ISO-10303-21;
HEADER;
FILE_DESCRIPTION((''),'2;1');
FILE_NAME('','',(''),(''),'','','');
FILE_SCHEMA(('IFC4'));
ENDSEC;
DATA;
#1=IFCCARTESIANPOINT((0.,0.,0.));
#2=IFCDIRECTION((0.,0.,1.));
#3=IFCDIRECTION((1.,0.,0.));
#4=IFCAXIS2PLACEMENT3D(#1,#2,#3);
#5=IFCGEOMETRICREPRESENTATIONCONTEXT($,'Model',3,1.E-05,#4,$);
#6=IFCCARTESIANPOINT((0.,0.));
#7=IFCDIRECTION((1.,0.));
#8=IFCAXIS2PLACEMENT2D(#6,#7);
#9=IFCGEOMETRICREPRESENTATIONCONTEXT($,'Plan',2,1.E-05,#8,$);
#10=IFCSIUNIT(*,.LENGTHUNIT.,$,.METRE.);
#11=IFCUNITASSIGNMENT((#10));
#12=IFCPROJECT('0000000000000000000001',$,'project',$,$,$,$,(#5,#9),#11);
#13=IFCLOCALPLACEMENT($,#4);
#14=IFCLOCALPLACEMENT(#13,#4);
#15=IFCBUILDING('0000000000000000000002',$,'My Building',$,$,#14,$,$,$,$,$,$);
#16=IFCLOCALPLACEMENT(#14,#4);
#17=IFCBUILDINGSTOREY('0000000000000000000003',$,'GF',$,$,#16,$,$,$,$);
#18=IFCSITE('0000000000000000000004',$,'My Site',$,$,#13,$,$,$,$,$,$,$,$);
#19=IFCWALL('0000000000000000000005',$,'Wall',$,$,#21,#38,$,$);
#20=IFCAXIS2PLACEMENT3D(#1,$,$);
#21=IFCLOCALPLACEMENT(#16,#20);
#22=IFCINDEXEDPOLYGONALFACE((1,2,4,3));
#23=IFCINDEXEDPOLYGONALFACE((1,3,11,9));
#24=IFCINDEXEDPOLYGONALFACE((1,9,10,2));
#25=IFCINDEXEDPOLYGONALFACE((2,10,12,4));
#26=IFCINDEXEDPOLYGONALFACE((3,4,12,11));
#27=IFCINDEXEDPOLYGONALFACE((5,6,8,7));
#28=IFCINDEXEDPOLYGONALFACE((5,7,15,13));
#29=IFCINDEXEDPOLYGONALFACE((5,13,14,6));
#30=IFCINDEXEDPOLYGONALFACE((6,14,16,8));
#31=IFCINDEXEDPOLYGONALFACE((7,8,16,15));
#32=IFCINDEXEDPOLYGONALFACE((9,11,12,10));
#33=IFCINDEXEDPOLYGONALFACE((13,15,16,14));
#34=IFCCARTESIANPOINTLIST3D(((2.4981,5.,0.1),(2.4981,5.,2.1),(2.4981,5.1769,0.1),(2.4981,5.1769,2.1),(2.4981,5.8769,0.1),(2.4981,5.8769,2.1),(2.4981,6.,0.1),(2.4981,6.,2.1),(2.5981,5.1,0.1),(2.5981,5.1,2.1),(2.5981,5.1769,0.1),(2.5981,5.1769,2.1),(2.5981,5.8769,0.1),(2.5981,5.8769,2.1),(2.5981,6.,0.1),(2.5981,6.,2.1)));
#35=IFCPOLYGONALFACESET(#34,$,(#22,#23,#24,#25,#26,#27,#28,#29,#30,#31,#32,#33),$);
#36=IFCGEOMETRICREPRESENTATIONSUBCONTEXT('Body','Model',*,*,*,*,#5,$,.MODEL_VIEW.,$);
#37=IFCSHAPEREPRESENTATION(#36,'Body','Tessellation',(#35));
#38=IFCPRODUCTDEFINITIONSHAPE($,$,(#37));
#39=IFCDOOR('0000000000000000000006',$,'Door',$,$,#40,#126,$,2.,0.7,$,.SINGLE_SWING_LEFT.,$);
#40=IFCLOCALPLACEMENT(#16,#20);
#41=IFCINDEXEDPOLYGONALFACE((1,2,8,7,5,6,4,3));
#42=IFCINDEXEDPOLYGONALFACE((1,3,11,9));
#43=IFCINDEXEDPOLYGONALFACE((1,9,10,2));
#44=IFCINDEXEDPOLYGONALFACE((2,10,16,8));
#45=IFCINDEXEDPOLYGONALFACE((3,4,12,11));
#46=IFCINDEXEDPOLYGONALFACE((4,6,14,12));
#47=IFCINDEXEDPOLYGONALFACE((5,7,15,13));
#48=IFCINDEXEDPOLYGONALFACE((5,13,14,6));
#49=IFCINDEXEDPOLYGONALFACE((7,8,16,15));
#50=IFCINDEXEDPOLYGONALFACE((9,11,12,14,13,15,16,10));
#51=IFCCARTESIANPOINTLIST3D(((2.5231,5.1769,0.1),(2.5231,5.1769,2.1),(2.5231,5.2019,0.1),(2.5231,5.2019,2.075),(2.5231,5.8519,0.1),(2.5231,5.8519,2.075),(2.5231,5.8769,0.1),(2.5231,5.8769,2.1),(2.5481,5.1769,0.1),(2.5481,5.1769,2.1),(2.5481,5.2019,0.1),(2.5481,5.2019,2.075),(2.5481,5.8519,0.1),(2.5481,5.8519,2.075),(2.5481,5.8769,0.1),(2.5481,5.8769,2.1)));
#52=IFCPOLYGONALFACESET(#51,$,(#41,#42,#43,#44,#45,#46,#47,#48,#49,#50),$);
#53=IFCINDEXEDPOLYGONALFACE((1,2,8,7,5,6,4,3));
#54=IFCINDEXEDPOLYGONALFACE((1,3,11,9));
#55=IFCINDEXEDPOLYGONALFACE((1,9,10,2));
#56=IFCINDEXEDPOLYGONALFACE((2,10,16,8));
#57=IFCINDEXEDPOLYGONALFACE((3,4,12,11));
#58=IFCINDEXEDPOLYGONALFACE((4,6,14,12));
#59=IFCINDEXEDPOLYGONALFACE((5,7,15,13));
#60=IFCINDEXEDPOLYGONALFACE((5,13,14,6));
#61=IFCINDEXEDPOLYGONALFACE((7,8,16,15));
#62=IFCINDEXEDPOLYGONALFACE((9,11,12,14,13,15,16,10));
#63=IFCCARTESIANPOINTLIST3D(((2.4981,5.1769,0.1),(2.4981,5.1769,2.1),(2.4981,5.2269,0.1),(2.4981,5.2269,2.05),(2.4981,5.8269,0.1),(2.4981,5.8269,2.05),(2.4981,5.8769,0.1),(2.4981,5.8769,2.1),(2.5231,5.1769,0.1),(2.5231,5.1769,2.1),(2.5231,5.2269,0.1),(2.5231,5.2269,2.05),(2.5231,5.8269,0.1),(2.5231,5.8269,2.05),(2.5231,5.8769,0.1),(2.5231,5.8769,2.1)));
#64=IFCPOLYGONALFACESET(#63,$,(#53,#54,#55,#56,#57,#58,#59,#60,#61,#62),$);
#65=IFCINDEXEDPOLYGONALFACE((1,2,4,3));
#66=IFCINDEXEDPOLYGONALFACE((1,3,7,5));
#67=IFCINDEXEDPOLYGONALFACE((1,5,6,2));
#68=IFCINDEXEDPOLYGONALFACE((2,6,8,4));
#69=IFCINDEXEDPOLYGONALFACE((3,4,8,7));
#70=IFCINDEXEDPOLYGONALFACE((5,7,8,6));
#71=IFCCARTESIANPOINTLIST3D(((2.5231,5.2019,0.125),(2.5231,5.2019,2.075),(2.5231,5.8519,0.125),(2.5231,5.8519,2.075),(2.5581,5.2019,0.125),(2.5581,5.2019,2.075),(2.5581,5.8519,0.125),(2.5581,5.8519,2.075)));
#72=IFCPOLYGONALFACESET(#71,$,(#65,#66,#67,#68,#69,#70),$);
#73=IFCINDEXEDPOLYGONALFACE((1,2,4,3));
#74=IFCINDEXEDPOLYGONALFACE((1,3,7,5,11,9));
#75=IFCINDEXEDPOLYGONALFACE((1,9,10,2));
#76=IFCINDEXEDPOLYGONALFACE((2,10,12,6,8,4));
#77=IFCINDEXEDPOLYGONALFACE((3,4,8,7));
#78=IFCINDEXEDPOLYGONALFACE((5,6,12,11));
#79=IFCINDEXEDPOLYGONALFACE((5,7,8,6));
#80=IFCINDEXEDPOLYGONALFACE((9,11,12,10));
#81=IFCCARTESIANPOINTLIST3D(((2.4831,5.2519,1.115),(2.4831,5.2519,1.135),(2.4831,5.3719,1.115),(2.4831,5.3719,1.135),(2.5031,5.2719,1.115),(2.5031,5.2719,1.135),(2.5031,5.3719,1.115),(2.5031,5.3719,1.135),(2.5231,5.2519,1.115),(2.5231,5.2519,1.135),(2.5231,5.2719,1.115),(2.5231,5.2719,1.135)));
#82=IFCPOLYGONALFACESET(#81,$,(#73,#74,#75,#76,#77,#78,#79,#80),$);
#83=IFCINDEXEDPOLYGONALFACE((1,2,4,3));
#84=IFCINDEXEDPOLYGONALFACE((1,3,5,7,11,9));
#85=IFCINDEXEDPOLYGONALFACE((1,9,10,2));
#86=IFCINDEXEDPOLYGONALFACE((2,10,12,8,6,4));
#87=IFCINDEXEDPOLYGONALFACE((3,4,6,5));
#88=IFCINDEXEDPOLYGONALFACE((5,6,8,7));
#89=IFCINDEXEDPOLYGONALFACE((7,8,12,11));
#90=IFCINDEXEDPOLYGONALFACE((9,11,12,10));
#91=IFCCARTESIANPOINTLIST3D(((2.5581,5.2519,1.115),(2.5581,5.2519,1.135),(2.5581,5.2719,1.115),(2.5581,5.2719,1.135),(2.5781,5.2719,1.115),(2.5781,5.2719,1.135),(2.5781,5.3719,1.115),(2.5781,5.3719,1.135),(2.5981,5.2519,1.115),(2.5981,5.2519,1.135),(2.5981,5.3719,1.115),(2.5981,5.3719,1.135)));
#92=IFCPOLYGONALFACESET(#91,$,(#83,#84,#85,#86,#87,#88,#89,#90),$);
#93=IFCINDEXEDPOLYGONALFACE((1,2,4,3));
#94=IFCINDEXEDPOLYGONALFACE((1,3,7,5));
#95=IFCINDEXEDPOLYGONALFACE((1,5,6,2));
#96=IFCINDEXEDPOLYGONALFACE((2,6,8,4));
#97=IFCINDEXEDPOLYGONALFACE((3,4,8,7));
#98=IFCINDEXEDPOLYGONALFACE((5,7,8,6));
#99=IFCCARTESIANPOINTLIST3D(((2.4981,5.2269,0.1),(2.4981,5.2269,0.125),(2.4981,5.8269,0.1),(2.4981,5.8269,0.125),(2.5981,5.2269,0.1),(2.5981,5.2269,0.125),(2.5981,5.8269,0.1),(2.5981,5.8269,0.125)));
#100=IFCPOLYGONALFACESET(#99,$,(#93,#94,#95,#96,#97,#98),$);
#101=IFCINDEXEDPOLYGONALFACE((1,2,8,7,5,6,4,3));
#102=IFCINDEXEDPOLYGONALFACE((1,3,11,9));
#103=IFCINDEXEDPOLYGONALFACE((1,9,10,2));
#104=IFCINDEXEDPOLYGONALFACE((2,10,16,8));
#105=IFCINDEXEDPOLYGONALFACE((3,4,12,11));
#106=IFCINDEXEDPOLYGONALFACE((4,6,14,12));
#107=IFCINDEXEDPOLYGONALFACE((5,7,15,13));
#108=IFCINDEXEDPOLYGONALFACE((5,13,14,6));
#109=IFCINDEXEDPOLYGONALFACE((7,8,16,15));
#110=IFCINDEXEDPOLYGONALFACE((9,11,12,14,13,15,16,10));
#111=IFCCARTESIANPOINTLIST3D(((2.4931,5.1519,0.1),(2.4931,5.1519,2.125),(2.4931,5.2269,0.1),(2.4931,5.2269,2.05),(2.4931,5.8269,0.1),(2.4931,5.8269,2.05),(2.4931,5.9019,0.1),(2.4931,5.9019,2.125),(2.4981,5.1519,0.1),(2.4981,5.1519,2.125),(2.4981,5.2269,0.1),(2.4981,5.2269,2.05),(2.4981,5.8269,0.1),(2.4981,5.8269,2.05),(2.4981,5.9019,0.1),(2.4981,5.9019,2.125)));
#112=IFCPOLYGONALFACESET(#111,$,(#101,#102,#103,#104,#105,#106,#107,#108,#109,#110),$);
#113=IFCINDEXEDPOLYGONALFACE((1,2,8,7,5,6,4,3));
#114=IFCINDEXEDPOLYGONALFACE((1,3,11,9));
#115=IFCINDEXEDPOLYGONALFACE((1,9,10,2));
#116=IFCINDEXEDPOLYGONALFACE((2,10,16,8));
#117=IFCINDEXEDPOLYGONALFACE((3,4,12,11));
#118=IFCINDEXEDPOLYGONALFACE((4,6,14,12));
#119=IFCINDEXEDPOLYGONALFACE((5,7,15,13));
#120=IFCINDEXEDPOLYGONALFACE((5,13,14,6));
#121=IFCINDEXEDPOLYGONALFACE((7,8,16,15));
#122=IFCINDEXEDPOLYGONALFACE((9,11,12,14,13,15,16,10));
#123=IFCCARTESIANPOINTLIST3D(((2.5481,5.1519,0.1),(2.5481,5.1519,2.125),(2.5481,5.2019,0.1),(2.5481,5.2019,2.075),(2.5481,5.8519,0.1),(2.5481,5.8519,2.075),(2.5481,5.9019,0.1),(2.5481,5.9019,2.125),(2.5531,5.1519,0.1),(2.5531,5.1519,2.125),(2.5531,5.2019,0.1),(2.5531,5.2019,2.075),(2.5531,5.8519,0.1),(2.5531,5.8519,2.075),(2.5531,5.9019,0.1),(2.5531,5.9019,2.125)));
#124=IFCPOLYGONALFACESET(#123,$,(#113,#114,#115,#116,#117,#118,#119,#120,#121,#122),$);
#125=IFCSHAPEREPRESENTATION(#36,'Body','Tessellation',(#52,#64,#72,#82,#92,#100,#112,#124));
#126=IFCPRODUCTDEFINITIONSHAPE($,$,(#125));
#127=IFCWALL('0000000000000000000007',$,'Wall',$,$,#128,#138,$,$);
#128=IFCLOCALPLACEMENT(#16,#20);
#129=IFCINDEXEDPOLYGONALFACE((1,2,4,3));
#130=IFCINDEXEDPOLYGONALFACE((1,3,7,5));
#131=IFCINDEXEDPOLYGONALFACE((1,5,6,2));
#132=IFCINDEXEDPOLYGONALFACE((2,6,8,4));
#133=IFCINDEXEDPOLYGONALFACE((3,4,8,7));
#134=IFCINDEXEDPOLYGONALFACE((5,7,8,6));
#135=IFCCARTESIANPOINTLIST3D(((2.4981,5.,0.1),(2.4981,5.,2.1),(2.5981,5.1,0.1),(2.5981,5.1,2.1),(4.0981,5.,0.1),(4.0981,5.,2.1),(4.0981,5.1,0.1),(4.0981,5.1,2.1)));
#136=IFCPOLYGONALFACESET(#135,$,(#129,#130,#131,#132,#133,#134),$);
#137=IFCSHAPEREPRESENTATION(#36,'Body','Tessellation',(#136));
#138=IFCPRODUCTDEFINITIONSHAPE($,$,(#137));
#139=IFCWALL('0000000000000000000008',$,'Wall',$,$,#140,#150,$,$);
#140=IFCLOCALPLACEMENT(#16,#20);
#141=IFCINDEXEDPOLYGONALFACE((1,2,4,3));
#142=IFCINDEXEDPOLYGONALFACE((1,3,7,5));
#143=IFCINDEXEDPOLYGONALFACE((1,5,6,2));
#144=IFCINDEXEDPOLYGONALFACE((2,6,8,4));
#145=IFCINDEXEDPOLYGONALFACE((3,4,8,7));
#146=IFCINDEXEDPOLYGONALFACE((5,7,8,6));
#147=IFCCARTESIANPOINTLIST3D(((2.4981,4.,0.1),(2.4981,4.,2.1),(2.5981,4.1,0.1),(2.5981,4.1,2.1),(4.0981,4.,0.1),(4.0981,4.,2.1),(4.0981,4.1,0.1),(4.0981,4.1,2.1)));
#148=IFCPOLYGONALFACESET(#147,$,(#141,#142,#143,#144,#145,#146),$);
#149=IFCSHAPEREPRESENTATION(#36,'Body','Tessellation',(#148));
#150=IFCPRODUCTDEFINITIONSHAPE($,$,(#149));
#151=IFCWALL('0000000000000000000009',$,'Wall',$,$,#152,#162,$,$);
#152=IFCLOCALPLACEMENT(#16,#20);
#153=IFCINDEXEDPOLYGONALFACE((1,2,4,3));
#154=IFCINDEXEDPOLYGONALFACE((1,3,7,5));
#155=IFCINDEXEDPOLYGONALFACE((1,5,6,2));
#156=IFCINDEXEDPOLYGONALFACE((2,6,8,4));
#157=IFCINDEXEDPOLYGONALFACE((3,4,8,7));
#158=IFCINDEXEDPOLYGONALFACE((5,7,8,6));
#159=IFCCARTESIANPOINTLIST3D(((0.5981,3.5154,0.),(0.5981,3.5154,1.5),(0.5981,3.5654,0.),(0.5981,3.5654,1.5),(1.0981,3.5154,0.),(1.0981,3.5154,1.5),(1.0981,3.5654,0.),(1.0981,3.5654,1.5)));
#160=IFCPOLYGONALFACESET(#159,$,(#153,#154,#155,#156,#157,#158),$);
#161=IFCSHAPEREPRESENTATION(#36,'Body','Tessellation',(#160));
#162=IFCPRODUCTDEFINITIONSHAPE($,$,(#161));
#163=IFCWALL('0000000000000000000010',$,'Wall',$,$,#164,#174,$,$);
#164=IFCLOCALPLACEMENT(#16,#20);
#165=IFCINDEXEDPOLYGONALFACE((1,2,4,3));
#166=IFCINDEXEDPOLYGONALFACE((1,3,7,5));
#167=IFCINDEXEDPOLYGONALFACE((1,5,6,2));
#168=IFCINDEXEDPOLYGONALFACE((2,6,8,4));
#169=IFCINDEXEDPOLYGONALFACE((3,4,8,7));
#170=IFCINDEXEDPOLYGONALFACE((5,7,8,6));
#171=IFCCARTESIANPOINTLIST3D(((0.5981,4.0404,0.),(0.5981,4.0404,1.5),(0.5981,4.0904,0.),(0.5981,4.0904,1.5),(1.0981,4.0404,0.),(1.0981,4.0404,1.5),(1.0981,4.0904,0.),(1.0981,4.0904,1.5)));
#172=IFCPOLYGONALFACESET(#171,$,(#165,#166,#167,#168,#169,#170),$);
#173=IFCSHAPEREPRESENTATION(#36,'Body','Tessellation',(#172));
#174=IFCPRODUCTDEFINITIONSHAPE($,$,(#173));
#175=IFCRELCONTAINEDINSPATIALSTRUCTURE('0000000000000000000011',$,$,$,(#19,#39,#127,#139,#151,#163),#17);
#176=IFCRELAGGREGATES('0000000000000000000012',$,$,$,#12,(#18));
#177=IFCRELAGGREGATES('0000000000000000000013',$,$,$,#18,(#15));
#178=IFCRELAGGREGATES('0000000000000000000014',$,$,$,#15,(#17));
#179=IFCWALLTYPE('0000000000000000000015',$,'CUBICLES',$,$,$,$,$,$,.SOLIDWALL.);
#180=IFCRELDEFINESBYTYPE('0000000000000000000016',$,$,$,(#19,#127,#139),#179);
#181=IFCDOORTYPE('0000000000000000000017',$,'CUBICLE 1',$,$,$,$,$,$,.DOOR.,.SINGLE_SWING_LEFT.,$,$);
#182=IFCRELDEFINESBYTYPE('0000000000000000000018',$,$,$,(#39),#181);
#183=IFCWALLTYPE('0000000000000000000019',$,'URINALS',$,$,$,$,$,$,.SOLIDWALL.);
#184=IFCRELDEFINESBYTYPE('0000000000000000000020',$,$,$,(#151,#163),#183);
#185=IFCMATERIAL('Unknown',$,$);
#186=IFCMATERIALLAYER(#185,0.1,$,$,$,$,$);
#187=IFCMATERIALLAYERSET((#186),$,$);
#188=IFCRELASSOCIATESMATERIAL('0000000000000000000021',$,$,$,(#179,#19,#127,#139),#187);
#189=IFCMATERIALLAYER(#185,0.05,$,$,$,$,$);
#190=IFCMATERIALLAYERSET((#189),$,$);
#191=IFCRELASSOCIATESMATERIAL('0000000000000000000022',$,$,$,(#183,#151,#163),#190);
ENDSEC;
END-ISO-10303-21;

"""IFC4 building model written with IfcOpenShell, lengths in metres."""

from ifc_helpers import new_model, entity, si_unit, frame, origin_with_axes, origin_2d_with_axis, place, context, subcontext, project, spatial, line, indexed_curve, outline, extrude, shape, source, transform, mapped, material, layer, layer_set, layer_usage, type_object, type_shapes, element, fill, save


model = new_model("IFC4")

# Units and contexts
model_context = context("Model", 3, precision=1e-05, world=origin_with_axes())
plan_context = context("Plan", 2, precision=1e-05, world=origin_2d_with_axis())
body_context_1 = subcontext(model_context, "Body", "Model", "MODEL_VIEW")
body_context_2 = subcontext(plan_context, "Body", "Plan", "PLAN_VIEW")
ifc_project = project(units=[si_unit("LENGTHUNIT", "METRE")], contexts=[model_context, plan_context])

# Site, building, storey
site_placement = place(None, origin_with_axes())
site = spatial("IfcSite", under=ifc_project, at=site_placement, Name="My Site")
building_placement = place(site_placement, origin_with_axes())
building = spatial("IfcBuilding", under=site, at=building_placement, Name="My Building")
storey_placement = place(building_placement, origin_with_axes())
storey = spatial("IfcBuildingStorey", under=building, at=storey_placement, Name="GF")

# Shared definitions
ifc_material = material(Name="Unknown")

# Wall, opening, door
ifc_layer_1 = layer(ifc_material, 0.1)
ifc_layer_set_1 = layer_set([ifc_layer_1])
wall_type_1 = type_object("IfcWallType", Name="CUBICLES", PredefinedType="SOLIDWALL", material=ifc_layer_set_1)
ifc_layer_usage_1 = layer_usage(ifc_layer_set_1, "AXIS2", "POSITIVE", 0.0)
wall_1_placement = place(storey_placement, frame((2.5981, 5.0, 0.1), z_axis=(0.0, 0.0, 1.0), x_axis=(0.0, 1.0, 0.0)))
wall_1 = element("IfcWall", 1, at=wall_1_placement, inside=storey, type_object=wall_type_1, material=ifc_layer_usage_1, Name="Wall", context=body_context_1, shape_type="SweptSolid", body=[
    extrude(outline(indexed_curve([(0.1, 0.0), (0.0, 0.1), (1.0, 0.1), (1.0, 0.0)], segments=[line(1, 2, 3, 4, 1)])), origin_with_axes(), (0.0, 0.0, 1.0), 2.0),
])
shared_shape_1 = source(origin_with_axes(), body_context_1, "Body", "SweptSolid", [
    extrude(outline(indexed_curve([(0.0, 0.0), (0.7, 0.0), (0.7, 2.0), (0.0, 2.0)], segments=[line(1, 2, 3, 4, 1)])), frame((0.0, -0.6, 0.0), z_axis=(0.0, -1.0, 0.0), x_axis=(1.0, 0.0, 0.0)), (0.0, 0.0, -1.0), 1.2),
])
opening_1_placement = place(wall_1_placement, frame((0.8769, 0.1, 0.0), z_axis=(0.0, 0.0, 1.0), x_axis=(-1.0, 0.0, 0.0)))
opening_1 = element("IfcOpeningElement", 2, at=opening_1_placement, cuts=wall_1, PredefinedType="OPENING", context=body_context_1, shape_type="MappedRepresentation", body=[
    mapped(shared_shape_1, transform((0.0, 0.0, 0.0), x_axis=(1.0, 0.0, 0.0), y_axis=(0.0, 1.0, 0.0), z_axis=(0.0, 0.0, 1.0), scale=1.0)),
])
door_type_1 = type_object("IfcDoorType", Name="CUBICLE 1", OperationType="SINGLE_SWING_LEFT", PredefinedType="DOOR")
shared_shape_2 = source(origin_with_axes(), body_context_1, "Body", "SweptSolid", [
    extrude(outline(indexed_curve([(0.0, 0.0), (0.0, 2.0), (0.7, 2.0), (0.7, 0.0), (0.675, 0.0), (0.675, 1.975), (0.025, 1.975), (0.025, 0.0)], segments=[line(1, 2, 3, 4, 5, 6, 7, 8, 1)])), frame((0.0, 0.025, 0.0), z_axis=(0.0, -1.0, 0.0), x_axis=(1.0, 0.0, 0.0)), (0.0, 0.0, -1.0), 0.025),
    extrude(outline(indexed_curve([(0.0, 0.0), (0.0, 2.0), (0.7, 2.0), (0.7, 0.0), (0.65, 0.0), (0.65, 1.95), (0.05, 1.95), (0.05, 0.0)], segments=[line(1, 2, 3, 4, 5, 6, 7, 8, 1)])), frame((0.0, 0.0, 0.0), z_axis=(0.0, -1.0, 0.0), x_axis=(1.0, 0.0, 0.0)), (0.0, 0.0, -1.0), 0.025),
    extrude(outline(indexed_curve([(0.0, 0.0), (0.65, 0.0), (0.65, 0.035), (0.0, 0.035)], segments=[line(1, 2, 3, 4, 1)])), frame((0.025, 0.025, 0.025), z_axis=(0.0, 0.0, 1.0), x_axis=(1.0, 0.0, 0.0)), (0.0, 0.0, 1.0), 1.95),
    extrude(outline(indexed_curve([(0.0, 0.0), (0.0, -0.04), (-0.12, -0.04), (-0.12, -0.02), (-0.02, -0.02), (-0.02, 0.0)], segments=[line(1, 2, 3, 4, 5, 6, 1)])), frame((0.625, 0.025, 1.015), z_axis=(0.0, 0.0, 1.0), x_axis=(1.0, 0.0, 0.0)), (0.0, 0.0, 1.0), 0.02),
    extrude(outline(indexed_curve([(0.0, 0.0), (0.0, 0.04), (-0.12, 0.04), (-0.12, 0.02), (-0.02, 0.02), (-0.02, 0.0)], segments=[line(1, 2, 3, 4, 5, 6, 1)])), frame((0.625, 0.06, 1.015), z_axis=(0.0, 0.0, 1.0), x_axis=(1.0, 0.0, 0.0)), (0.0, 0.0, 1.0), 0.02),
    extrude(outline(indexed_curve([(0.0, 0.0), (0.6, 0.0), (0.6, 0.1), (0.0, 0.1)], segments=[line(1, 2, 3, 4, 1)])), frame((0.05, 0.0, 0.0), z_axis=(0.0, 0.0, 1.0), x_axis=(1.0, 0.0, 0.0)), (0.0, 0.0, 1.0), 0.025),
    extrude(outline(indexed_curve([(0.0, 0.0), (0.0, 2.025), (0.75, 2.025), (0.75, 0.0), (0.675, 0.0), (0.675, 1.95), (0.075, 1.95), (0.075, 0.0)], segments=[line(1, 2, 3, 4, 5, 6, 7, 8, 1)])), frame((-0.025, -0.005, 0.0), z_axis=(0.0, -1.0, 0.0), x_axis=(1.0, 0.0, 0.0)), (0.0, 0.0, -1.0), 0.005),
    extrude(outline(indexed_curve([(0.0, 0.0), (0.0, 2.025), (0.75, 2.025), (0.75, 0.0), (0.7, 0.0), (0.7, 1.975), (0.05, 1.975), (0.05, 0.0)], segments=[line(1, 2, 3, 4, 5, 6, 7, 8, 1)])), frame((-0.025, 0.05, 0.0), z_axis=(0.0, -1.0, 0.0), x_axis=(1.0, 0.0, 0.0)), (0.0, 0.0, -1.0), 0.005),
])
shared_shape_3 = source(origin_with_axes(), body_context_2, "Body", "Curve2D", [
    entity("IfcIndexedPolyCurve", entity("IfcCartesianPointList2D", [[0.0, 0.0], [0.0, 0.05], [0.025, 0.05], [0.025, 0.025], [0.05, 0.025], [0.05, 0.0]]), [entity("IfcLineIndex", [1, 2, 3, 4, 5, 6, 1])]),
    entity("IfcIndexedPolyCurve", entity("IfcCartesianPointList2D", [[0.7, 0.0], [0.7, 0.05], [0.675, 0.05], [0.675, 0.025], [0.65, 0.025], [0.65, 0.0]]), [entity("IfcLineIndex", [1, 2, 3, 4, 5, 6, 1])]),
    entity("IfcTrimmedCurve", entity("IfcEllipse", entity("IfcAxis2Placement2D", entity("IfcCartesianPoint", [0.06, 0.05]), entity("IfcDirection", [1.0, 0.0])), 0.615, 0.65), [entity("IfcCartesianPoint", [0.675, 0.05])], [entity("IfcCartesianPoint", [0.06, 0.7])], True, "CARTESIAN"),
    entity("IfcIndexedPolyCurve", entity("IfcCartesianPointList2D", [[0.025, 0.05], [0.06, 0.05], [0.06, 0.7], [0.025, 0.7]]), [entity("IfcLineIndex", [1, 2, 3, 4, 1])]),
])
type_shapes(door_type_1, [shared_shape_2, shared_shape_3])
door_1_placement = place(opening_1_placement, frame((0.0, 0.0, 0.0), z_axis=(0.0, 0.0, 1.0), x_axis=(1.0, 0.0, 0.0)))
door_1 = element("IfcDoor", 3, at=door_1_placement, inside=storey, type_object=door_type_1, Name="Door", OperationType="SINGLE_SWING_LEFT", OverallHeight=2.0, OverallWidth=0.7, shapes=[
    shape(body_context_1, "Body", "MappedRepresentation", [mapped(shared_shape_2, transform((0.0, 0.0, 0.0), x_axis=(1.0, 0.0, 0.0), y_axis=(0.0, 1.0, 0.0), z_axis=(0.0, 0.0, 1.0), scale=1.0))]),
    shape(body_context_2, "Body", "MappedRepresentation", [mapped(shared_shape_3, transform((0.0, 0.0, 0.0), x_axis=(1.0, 0.0, 0.0), y_axis=(0.0, 1.0, 0.0), z_axis=(0.0, 0.0, 1.0), scale=1.0))]),
])
fill(opening_1, door_1)

# Walls
ifc_layer_usage_2 = layer_usage(ifc_layer_set_1, "AXIS2", "POSITIVE", 0.0)
wall_2_placement = place(storey_placement, frame((2.5981, 5.0, 0.1), z_axis=(0.0, 0.0, 1.0), x_axis=(1.0, 0.0, 0.0)))
element("IfcWall", 4, at=wall_2_placement, inside=storey, type_object=wall_type_1, material=ifc_layer_usage_2, Name="Wall", context=body_context_1, shape_type="SweptSolid", body=[
    extrude(outline(indexed_curve([(-0.1, 0.0), (0.0, 0.1), (1.5, 0.1), (1.5, 0.0)], segments=[line(1, 2, 3, 4, 1)])), origin_with_axes(), (0.0, 0.0, 1.0), 2.0),
])
ifc_layer_usage_3 = layer_usage(ifc_layer_set_1, "AXIS2", "POSITIVE", 0.0)
wall_3_placement = place(storey_placement, frame((2.5981, 4.0, 0.1), z_axis=(0.0, 0.0, 1.0), x_axis=(1.0, 0.0, 0.0)))
element("IfcWall", 5, at=wall_3_placement, inside=storey, type_object=wall_type_1, material=ifc_layer_usage_3, Name="Wall", context=body_context_1, shape_type="SweptSolid", body=[
    extrude(outline(indexed_curve([(-0.1, 0.0), (0.0, 0.1), (1.5, 0.1), (1.5, 0.0)], segments=[line(1, 2, 3, 4, 1)])), origin_with_axes(), (0.0, 0.0, 1.0), 2.0),
])
ifc_layer_2 = layer(ifc_material, 0.05)
ifc_layer_set_2 = layer_set([ifc_layer_2])
ifc_layer_usage_4 = layer_usage(ifc_layer_set_2, "AXIS2", "POSITIVE", 0.0)
wall_type_2 = type_object("IfcWallType", Name="URINALS", PredefinedType="SOLIDWALL", material=ifc_layer_set_2)
wall_4_placement = place(storey_placement, frame((0.5981, 3.5154, 0.0), z_axis=(0.0, 0.0, 1.0), x_axis=(1.0, 0.0, 0.0)))
element("IfcWall", 6, at=wall_4_placement, inside=storey, type_object=wall_type_2, material=ifc_layer_usage_4, Name="Wall", context=body_context_1, shape_type="SweptSolid", body=[
    extrude(outline(indexed_curve([(0.0, 0.0), (0.0, 0.05), (0.5, 0.05), (0.5, 0.0)], segments=[line(1, 2, 3, 4, 1)])), origin_with_axes(), (0.0, 0.0, 1.0), 1.5),
])
ifc_layer_usage_5 = layer_usage(ifc_layer_set_2, "AXIS2", "POSITIVE", 0.0)
wall_5_placement = place(storey_placement, frame((0.5981, 4.0404, 0.0), z_axis=(0.0, 0.0, 1.0), x_axis=(1.0, 0.0, 0.0)))
element("IfcWall", 7, at=wall_5_placement, inside=storey, type_object=wall_type_2, material=ifc_layer_usage_5, Name="Wall", context=body_context_1, shape_type="SweptSolid", body=[
    extrude(outline(indexed_curve([(0.0, 0.0), (0.0, 0.05), (0.5, 0.05), (0.5, 0.0)], segments=[line(1, 2, 3, 4, 1)])), origin_with_axes(), (0.0, 0.0, 1.0), 1.5),
])

save(model, "model.ifc")
